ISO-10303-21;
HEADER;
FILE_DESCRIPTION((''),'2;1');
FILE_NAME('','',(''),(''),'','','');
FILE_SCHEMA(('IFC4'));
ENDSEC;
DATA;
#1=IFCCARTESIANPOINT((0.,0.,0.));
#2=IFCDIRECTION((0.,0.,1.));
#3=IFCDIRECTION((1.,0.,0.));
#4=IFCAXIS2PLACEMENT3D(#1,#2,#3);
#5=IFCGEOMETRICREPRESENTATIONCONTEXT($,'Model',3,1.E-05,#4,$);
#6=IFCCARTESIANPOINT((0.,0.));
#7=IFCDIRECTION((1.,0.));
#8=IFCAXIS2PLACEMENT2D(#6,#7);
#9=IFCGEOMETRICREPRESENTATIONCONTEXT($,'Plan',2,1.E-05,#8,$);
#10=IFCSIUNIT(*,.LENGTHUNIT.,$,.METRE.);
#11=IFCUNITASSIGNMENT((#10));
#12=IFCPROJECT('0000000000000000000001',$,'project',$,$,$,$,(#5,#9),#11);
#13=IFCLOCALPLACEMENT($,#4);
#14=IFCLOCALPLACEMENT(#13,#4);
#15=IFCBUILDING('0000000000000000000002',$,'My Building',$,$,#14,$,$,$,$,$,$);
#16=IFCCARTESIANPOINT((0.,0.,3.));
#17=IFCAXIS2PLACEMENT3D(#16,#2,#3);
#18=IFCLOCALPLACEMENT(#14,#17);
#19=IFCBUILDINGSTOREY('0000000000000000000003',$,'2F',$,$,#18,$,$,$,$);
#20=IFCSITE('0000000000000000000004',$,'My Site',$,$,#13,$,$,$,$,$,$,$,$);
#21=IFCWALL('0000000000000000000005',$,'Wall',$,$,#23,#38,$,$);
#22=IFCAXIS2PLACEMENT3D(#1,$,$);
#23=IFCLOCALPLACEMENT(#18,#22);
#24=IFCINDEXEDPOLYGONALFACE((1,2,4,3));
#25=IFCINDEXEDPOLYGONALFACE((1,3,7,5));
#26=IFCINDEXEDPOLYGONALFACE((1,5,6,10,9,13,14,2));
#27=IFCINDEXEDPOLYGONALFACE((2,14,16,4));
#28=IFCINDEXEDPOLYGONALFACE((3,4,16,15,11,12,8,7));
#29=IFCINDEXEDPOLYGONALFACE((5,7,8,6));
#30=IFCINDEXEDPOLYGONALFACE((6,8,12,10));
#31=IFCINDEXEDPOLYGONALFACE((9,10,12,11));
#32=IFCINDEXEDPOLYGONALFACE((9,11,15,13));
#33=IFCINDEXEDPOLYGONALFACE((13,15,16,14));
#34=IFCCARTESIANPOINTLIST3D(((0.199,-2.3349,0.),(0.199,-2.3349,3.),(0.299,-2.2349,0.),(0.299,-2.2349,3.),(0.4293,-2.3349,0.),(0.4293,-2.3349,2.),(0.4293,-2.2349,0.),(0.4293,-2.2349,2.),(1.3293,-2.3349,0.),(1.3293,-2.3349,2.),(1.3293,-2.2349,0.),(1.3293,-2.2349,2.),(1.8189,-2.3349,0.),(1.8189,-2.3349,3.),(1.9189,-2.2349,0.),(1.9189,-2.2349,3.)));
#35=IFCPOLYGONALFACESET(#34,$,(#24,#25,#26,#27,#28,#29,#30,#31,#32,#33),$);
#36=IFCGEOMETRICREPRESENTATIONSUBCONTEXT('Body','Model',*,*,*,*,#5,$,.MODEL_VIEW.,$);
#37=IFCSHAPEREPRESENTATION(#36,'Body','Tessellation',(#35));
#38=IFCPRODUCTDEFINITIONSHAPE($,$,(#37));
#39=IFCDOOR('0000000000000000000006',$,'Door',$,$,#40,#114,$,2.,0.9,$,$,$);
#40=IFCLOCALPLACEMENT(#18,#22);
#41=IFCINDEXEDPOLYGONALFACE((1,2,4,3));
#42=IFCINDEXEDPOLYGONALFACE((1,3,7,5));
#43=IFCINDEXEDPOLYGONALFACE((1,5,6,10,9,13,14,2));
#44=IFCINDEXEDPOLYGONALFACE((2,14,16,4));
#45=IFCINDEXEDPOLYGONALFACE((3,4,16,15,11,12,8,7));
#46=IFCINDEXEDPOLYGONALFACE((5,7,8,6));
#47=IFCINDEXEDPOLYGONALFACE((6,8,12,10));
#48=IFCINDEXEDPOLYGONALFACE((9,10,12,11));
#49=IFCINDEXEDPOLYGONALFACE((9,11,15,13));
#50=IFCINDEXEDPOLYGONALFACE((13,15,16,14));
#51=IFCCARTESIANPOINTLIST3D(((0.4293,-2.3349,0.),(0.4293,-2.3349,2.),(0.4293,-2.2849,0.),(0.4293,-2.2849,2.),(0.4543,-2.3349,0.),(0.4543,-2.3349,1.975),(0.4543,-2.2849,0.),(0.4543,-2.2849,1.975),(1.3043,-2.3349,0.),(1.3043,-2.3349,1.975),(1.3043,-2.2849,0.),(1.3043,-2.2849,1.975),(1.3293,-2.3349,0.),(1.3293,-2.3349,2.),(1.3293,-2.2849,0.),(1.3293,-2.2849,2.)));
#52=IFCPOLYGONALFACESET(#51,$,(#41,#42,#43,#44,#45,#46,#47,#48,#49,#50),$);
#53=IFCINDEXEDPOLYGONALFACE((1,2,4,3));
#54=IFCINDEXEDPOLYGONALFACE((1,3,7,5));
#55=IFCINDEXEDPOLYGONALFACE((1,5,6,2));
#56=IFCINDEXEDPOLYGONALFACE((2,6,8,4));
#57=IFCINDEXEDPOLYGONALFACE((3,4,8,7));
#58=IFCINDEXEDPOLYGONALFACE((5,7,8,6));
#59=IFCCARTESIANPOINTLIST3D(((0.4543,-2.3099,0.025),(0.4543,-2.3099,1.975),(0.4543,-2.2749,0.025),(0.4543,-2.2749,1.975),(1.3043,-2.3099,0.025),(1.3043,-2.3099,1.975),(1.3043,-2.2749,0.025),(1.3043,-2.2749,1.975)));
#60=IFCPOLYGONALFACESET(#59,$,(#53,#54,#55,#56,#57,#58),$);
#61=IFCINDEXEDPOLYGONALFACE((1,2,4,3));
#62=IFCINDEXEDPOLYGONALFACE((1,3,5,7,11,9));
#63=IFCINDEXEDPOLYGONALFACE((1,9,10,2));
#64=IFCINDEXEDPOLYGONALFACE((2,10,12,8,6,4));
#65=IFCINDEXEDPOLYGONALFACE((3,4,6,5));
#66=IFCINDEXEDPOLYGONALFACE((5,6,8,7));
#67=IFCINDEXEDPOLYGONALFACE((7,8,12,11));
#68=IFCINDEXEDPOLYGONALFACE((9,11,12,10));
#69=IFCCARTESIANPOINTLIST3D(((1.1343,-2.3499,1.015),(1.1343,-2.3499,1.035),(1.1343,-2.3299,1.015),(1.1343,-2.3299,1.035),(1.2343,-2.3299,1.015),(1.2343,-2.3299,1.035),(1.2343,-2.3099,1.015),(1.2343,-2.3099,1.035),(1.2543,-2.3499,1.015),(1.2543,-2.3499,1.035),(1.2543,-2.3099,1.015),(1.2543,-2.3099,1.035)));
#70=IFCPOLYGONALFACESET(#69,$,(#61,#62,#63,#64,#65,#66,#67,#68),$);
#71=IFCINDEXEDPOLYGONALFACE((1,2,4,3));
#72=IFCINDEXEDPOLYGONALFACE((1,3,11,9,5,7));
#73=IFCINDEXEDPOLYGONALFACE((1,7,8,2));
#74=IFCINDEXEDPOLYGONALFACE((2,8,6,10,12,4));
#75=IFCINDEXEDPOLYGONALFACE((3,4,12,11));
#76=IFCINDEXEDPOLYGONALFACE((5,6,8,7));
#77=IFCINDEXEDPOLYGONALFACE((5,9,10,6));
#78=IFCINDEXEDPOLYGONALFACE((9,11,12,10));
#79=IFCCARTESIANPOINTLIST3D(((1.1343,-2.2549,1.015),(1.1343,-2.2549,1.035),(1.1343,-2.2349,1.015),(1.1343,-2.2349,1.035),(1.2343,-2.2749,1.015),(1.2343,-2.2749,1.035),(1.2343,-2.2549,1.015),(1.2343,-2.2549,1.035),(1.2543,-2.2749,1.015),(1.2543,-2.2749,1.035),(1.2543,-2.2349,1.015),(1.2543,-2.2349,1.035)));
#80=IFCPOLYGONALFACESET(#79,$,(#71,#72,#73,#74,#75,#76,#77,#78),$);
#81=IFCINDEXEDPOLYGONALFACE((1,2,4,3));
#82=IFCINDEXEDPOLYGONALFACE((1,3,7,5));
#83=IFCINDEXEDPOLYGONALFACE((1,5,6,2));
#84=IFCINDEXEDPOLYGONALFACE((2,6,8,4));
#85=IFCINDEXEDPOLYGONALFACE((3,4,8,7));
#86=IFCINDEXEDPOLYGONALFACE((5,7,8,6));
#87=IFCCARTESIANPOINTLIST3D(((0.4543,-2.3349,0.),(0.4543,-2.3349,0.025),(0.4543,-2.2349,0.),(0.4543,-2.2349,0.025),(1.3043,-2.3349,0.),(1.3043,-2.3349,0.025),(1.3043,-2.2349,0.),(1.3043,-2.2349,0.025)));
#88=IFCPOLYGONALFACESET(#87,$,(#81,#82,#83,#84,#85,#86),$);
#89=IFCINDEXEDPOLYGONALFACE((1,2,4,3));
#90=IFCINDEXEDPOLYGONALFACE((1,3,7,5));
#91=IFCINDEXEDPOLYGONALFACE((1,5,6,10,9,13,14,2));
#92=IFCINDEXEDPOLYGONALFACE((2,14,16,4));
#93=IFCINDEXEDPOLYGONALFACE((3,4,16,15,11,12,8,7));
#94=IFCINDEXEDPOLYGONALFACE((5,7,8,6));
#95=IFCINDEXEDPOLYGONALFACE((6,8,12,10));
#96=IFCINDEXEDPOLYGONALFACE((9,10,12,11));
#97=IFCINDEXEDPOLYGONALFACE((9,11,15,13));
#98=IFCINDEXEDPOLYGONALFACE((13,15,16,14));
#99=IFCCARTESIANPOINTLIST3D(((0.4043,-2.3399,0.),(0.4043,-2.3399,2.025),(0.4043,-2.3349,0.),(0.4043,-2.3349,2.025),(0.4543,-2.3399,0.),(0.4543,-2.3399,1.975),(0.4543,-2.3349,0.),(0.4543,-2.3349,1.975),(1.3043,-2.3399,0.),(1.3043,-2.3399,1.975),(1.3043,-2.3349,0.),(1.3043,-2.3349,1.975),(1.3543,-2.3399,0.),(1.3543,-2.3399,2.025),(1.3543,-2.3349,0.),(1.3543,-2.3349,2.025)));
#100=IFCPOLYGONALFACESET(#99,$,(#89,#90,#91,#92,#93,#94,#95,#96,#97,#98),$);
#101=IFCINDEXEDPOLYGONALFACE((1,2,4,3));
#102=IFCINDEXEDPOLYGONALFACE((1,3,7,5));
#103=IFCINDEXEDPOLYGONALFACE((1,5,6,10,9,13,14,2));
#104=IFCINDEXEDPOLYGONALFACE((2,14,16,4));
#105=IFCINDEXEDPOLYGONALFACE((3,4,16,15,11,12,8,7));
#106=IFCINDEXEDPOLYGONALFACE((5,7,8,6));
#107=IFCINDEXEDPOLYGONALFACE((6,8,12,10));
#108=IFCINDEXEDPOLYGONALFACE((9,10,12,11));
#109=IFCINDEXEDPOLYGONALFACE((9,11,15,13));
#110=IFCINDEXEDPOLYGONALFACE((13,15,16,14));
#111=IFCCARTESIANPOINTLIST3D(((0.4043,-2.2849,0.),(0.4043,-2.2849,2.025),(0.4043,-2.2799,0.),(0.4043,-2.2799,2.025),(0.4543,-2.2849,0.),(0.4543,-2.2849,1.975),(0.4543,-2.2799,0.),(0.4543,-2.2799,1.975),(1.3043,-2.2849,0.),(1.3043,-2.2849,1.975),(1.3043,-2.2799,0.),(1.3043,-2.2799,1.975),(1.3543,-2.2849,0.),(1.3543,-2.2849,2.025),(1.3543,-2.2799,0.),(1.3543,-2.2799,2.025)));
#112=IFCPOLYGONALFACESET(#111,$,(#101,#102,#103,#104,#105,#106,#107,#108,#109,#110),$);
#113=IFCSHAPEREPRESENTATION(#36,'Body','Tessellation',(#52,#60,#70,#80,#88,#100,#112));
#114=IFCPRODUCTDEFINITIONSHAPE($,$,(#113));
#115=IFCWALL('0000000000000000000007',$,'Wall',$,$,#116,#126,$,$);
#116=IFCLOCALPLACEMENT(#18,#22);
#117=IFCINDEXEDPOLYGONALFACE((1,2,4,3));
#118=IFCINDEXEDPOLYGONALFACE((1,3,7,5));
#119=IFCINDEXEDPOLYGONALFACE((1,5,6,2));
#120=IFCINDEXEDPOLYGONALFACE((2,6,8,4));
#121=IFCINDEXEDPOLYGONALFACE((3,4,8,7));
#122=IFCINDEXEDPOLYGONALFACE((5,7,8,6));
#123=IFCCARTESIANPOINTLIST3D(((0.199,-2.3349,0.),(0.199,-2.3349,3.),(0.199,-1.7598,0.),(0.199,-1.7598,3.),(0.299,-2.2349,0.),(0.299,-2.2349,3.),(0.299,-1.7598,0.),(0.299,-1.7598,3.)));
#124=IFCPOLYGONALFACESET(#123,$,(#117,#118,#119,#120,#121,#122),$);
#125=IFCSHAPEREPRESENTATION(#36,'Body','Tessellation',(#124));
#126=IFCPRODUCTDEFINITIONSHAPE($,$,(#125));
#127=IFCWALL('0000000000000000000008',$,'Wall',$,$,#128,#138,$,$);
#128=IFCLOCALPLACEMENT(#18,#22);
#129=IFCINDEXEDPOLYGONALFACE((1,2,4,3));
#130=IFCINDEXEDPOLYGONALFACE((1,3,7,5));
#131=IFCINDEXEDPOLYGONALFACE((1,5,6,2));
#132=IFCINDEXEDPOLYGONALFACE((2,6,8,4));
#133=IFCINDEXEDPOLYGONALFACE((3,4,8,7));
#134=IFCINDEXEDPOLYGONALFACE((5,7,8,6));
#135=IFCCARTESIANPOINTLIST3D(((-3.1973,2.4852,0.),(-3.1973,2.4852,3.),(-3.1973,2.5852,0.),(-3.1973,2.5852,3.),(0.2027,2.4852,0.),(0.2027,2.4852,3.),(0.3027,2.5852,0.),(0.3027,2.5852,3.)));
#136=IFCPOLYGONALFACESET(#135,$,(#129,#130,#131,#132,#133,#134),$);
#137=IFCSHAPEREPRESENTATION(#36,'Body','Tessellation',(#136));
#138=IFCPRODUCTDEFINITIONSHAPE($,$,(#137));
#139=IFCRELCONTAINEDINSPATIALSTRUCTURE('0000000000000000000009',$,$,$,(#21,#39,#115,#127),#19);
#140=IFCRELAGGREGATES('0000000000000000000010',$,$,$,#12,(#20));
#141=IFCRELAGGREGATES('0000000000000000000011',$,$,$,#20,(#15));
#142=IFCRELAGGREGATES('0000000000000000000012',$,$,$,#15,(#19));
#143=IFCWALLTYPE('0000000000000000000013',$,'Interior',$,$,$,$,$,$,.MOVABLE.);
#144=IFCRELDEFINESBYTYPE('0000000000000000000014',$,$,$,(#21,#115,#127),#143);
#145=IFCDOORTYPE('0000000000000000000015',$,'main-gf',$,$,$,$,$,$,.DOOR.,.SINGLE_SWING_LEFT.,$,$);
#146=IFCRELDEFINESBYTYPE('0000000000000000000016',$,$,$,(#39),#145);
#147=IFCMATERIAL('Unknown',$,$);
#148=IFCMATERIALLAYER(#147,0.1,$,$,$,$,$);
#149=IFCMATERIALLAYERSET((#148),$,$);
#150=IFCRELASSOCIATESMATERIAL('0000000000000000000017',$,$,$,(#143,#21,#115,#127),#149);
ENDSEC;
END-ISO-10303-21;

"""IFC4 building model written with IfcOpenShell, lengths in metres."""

from ifc_helpers import new_model, entity, si_unit, frame, origin_with_axes, origin_2d_with_axis, place, context, subcontext, project, spatial, line, indexed_curve, outline, extrude, shape, source, transform, mapped, material, layer, layer_set, layer_usage, type_object, type_shapes, element, fill, save


model = new_model("IFC4")

# Units and contexts
model_context = context("Model", 3, precision=1e-05, world=origin_with_axes())
plan_context = context("Plan", 2, precision=1e-05, world=origin_2d_with_axis())
body_context_1 = subcontext(model_context, "Body", "Model", "MODEL_VIEW")
body_context_2 = subcontext(plan_context, "Body", "Plan", "PLAN_VIEW")
ifc_project = project(units=[si_unit("LENGTHUNIT", "METRE")], contexts=[model_context, plan_context])

# Site, building, storey
site_placement = place(None, origin_with_axes())
site = spatial("IfcSite", under=ifc_project, at=site_placement, Name="My Site")
building_placement = place(site_placement, origin_with_axes())
building = spatial("IfcBuilding", under=site, at=building_placement, Name="My Building")
storey_placement = place(building_placement, frame((0.0, 0.0, 3.0), z_axis=(0.0, 0.0, 1.0), x_axis=(1.0, 0.0, 0.0)))
storey = spatial("IfcBuildingStorey", under=building, at=storey_placement, Name="2F")

# Shared definitions
ifc_material = material(Name="Unknown")

# Shared definitions
ifc_layer_1 = layer(ifc_material, 0.1)
ifc_layer_set_1 = layer_set([ifc_layer_1])
wall_type = type_object("IfcWallType", Name="Interior", PredefinedType="MOVABLE", material=ifc_layer_set_1)

# Wall, opening, door
ifc_layer_usage_1 = layer_usage(ifc_layer_set_1, "AXIS2", "POSITIVE", 0.0)
wall_1_placement = place(storey_placement, frame((1.9189, -2.2349, 0.0), z_axis=(0.0, 0.0, 1.0), x_axis=(-1.0, 0.0, 0.0)))
wall_1 = element("IfcWall", 1, at=wall_1_placement, inside=storey, type_object=wall_type, material=ifc_layer_usage_1, Name="Wall", context=body_context_1, shape_type="SweptSolid", body=[
    extrude(outline(indexed_curve([(0.0, 0.0), (0.1, 0.1), (1.7199, 0.1), (1.6199, 0.0)], segments=[line(1, 2, 3, 4, 1)])), origin_with_axes(), (0.0, 0.0, 1.0), 3.0),
])
shared_shape_1 = source(origin_with_axes(), body_context_1, "Body", "SweptSolid", [
    extrude(outline(indexed_curve([(0.0, 0.0), (0.9, 0.0), (0.9, 2.0), (0.0, 2.0)], segments=[line(1, 2, 3, 4, 1)])), frame((0.0, -0.6, 0.0), z_axis=(0.0, -1.0, 0.0), x_axis=(1.0, 0.0, 0.0)), (0.0, 0.0, -1.0), 1.2),
])
opening_1_placement = place(wall_1_placement, frame((1.4896, 0.1, 0.0), z_axis=(0.0, 0.0, 1.0), x_axis=(-1.0, 0.0, 0.0)))
opening_1 = element("IfcOpeningElement", 2, at=opening_1_placement, cuts=wall_1, PredefinedType="OPENING", context=body_context_1, shape_type="MappedRepresentation", body=[
    mapped(shared_shape_1, transform((0.0, 0.0, 0.0), x_axis=(1.0, 0.0, 0.0), y_axis=(0.0, 1.0, 0.0), z_axis=(0.0, 0.0, 1.0), scale=1.0)),
])
door_type = type_object("IfcDoorType", Name="main-gf", OperationType="SINGLE_SWING_LEFT", PredefinedType="DOOR")
shared_shape_2 = source(origin_with_axes(), body_context_1, "Body", "SweptSolid", [
    extrude(outline(indexed_curve([(0.0, 0.0), (0.0, 2.0), (0.9, 2.0), (0.9, 0.0), (0.875, 0.0), (0.875, 1.975), (0.025, 1.975), (0.025, 0.0)], segments=[line(1, 2, 3, 4, 5, 6, 7, 8, 1)])), frame((0.0, 0.0, 0.0), z_axis=(0.0, -1.0, 0.0), x_axis=(1.0, 0.0, 0.0)), (0.0, 0.0, -1.0), 0.05),
    extrude(outline(indexed_curve([(0.0, 0.0), (0.85, 0.0), (0.85, 0.035), (0.0, 0.035)], segments=[line(1, 2, 3, 4, 1)])), frame((0.025, 0.025, 0.025), z_axis=(0.0, 0.0, 1.0), x_axis=(1.0, 0.0, 0.0)), (0.0, 0.0, 1.0), 1.95),
    extrude(outline(indexed_curve([(0.0, 0.0), (0.0, -0.04), (-0.12, -0.04), (-0.12, -0.02), (-0.02, -0.02), (-0.02, 0.0)], segments=[line(1, 2, 3, 4, 5, 6, 1)])), frame((0.825, 0.025, 1.015), z_axis=(0.0, 0.0, 1.0), x_axis=(1.0, 0.0, 0.0)), (0.0, 0.0, 1.0), 0.02),
    extrude(outline(indexed_curve([(0.0, 0.0), (0.0, 0.04), (-0.12, 0.04), (-0.12, 0.02), (-0.02, 0.02), (-0.02, 0.0)], segments=[line(1, 2, 3, 4, 5, 6, 1)])), frame((0.825, 0.06, 1.015), z_axis=(0.0, 0.0, 1.0), x_axis=(1.0, 0.0, 0.0)), (0.0, 0.0, 1.0), 0.02),
    extrude(outline(indexed_curve([(0.0, 0.0), (0.85, 0.0), (0.85, 0.1), (0.0, 0.1)], segments=[line(1, 2, 3, 4, 1)])), frame((0.025, 0.0, 0.0), z_axis=(0.0, 0.0, 1.0), x_axis=(1.0, 0.0, 0.0)), (0.0, 0.0, 1.0), 0.025),
    extrude(outline(indexed_curve([(0.0, 0.0), (0.0, 2.025), (0.95, 2.025), (0.95, 0.0), (0.9, 0.0), (0.9, 1.975), (0.05, 1.975), (0.05, 0.0)], segments=[line(1, 2, 3, 4, 5, 6, 7, 8, 1)])), frame((-0.025, -0.005, 0.0), z_axis=(0.0, -1.0, 0.0), x_axis=(1.0, 0.0, 0.0)), (0.0, 0.0, -1.0), 0.005),
    extrude(outline(indexed_curve([(0.0, 0.0), (0.0, 2.025), (0.95, 2.025), (0.95, 0.0), (0.9, 0.0), (0.9, 1.975), (0.05, 1.975), (0.05, 0.0)], segments=[line(1, 2, 3, 4, 5, 6, 7, 8, 1)])), frame((-0.025, 0.05, 0.0), z_axis=(0.0, -1.0, 0.0), x_axis=(1.0, 0.0, 0.0)), (0.0, 0.0, -1.0), 0.005),
])
shared_shape_3 = source(origin_with_axes(), body_context_2, "Body", "Curve2D", [
    entity("IfcIndexedPolyCurve", entity("IfcCartesianPointList2D", [[0.0, 0.0], [0.025, 0.0], [0.025, 0.05], [0.0, 0.05]]), [entity("IfcLineIndex", [1, 2, 3, 4, 1])]),
    entity("IfcIndexedPolyCurve", entity("IfcCartesianPointList2D", [[0.9, 0.0], [0.875, 0.0], [0.875, 0.05], [0.9, 0.05]]), [entity("IfcLineIndex", [1, 2, 3, 4, 1])]),
    entity("IfcIndexedPolyCurve", entity("IfcCartesianPointList2D", [[0.025, 0.05], [0.025, -0.8], [0.06, -0.8]])),
    entity("IfcTrimmedCurve", entity("IfcEllipse", entity("IfcAxis2Placement2D", entity("IfcCartesianPoint", [0.06, 0.05]), entity("IfcDirection", [1.0, 0.0])), 0.815, 0.85), [entity("IfcCartesianPoint", [0.06, -0.8])], [entity("IfcCartesianPoint", [0.06, 0.9])], True, "CARTESIAN"),
    entity("IfcIndexedPolyCurve", entity("IfcCartesianPointList2D", [[0.025, 0.05], [0.06, 0.05], [0.06, 0.9], [0.025, 0.9]]), [entity("IfcLineIndex", [1, 2, 3, 4, 1])]),
])
type_shapes(door_type, [shared_shape_2, shared_shape_3])
door_1_placement = place(opening_1_placement, frame((0.0, 0.0, 0.0), z_axis=(0.0, 0.0, 1.0), x_axis=(1.0, 0.0, 0.0)))
door_1 = element("IfcDoor", 3, at=door_1_placement, inside=storey, type_object=door_type, Name="Door", OverallHeight=2.0, OverallWidth=0.9, shapes=[
    shape(body_context_1, "Body", "MappedRepresentation", [mapped(shared_shape_2, transform((0.0, 0.0, 0.0), x_axis=(1.0, 0.0, 0.0), y_axis=(0.0, 1.0, 0.0), z_axis=(0.0, 0.0, 1.0), scale=1.0))]),
    shape(body_context_2, "Body", "MappedRepresentation", [mapped(shared_shape_3, transform((0.0, 0.0, 0.0), x_axis=(1.0, 0.0, 0.0), y_axis=(0.0, 1.0, 0.0), z_axis=(0.0, 0.0, 1.0), scale=1.0))]),
])
fill(opening_1, door_1)

# Walls
ifc_layer_usage_2 = layer_usage(ifc_layer_set_1, "AXIS2", "POSITIVE", 0.0)
wall_2_placement = place(storey_placement, frame((0.199, -1.7598, 0.0), z_axis=(0.0, 0.0, 1.0), x_axis=(0.0, -1.0, 0.0)))
element("IfcWall", 4, at=wall_2_placement, inside=storey, type_object=wall_type, material=ifc_layer_usage_2, Name="Wall", context=body_context_1, shape_type="SweptSolid", body=[
    extrude(outline(indexed_curve([(0.0, 0.0), (0.0, 0.1), (0.4751, 0.1), (0.5751, 0.0)], segments=[line(1, 2, 3, 4, 1)])), origin_with_axes(), (0.0, 0.0, 1.0), 3.0),
])
ifc_layer_usage_3 = layer_usage(ifc_layer_set_1, "AXIS2", "POSITIVE", 0.0)
wall_3_placement = place(storey_placement, frame((-3.1973, 2.4852, 0.0), z_axis=(0.0, 0.0, 1.0), x_axis=(1.0, 0.0, 0.0)))
element("IfcWall", 5, at=wall_3_placement, inside=storey, type_object=wall_type, material=ifc_layer_usage_3, Name="Wall", context=body_context_1, shape_type="SweptSolid", body=[
    extrude(outline(indexed_curve([(0.0, 0.0), (0.0, 0.1), (3.5, 0.1), (3.4, 0.0)], segments=[line(1, 2, 3, 4, 1)])), origin_with_axes(), (0.0, 0.0, 1.0), 3.0),
])

save(model, "model.ifc")
